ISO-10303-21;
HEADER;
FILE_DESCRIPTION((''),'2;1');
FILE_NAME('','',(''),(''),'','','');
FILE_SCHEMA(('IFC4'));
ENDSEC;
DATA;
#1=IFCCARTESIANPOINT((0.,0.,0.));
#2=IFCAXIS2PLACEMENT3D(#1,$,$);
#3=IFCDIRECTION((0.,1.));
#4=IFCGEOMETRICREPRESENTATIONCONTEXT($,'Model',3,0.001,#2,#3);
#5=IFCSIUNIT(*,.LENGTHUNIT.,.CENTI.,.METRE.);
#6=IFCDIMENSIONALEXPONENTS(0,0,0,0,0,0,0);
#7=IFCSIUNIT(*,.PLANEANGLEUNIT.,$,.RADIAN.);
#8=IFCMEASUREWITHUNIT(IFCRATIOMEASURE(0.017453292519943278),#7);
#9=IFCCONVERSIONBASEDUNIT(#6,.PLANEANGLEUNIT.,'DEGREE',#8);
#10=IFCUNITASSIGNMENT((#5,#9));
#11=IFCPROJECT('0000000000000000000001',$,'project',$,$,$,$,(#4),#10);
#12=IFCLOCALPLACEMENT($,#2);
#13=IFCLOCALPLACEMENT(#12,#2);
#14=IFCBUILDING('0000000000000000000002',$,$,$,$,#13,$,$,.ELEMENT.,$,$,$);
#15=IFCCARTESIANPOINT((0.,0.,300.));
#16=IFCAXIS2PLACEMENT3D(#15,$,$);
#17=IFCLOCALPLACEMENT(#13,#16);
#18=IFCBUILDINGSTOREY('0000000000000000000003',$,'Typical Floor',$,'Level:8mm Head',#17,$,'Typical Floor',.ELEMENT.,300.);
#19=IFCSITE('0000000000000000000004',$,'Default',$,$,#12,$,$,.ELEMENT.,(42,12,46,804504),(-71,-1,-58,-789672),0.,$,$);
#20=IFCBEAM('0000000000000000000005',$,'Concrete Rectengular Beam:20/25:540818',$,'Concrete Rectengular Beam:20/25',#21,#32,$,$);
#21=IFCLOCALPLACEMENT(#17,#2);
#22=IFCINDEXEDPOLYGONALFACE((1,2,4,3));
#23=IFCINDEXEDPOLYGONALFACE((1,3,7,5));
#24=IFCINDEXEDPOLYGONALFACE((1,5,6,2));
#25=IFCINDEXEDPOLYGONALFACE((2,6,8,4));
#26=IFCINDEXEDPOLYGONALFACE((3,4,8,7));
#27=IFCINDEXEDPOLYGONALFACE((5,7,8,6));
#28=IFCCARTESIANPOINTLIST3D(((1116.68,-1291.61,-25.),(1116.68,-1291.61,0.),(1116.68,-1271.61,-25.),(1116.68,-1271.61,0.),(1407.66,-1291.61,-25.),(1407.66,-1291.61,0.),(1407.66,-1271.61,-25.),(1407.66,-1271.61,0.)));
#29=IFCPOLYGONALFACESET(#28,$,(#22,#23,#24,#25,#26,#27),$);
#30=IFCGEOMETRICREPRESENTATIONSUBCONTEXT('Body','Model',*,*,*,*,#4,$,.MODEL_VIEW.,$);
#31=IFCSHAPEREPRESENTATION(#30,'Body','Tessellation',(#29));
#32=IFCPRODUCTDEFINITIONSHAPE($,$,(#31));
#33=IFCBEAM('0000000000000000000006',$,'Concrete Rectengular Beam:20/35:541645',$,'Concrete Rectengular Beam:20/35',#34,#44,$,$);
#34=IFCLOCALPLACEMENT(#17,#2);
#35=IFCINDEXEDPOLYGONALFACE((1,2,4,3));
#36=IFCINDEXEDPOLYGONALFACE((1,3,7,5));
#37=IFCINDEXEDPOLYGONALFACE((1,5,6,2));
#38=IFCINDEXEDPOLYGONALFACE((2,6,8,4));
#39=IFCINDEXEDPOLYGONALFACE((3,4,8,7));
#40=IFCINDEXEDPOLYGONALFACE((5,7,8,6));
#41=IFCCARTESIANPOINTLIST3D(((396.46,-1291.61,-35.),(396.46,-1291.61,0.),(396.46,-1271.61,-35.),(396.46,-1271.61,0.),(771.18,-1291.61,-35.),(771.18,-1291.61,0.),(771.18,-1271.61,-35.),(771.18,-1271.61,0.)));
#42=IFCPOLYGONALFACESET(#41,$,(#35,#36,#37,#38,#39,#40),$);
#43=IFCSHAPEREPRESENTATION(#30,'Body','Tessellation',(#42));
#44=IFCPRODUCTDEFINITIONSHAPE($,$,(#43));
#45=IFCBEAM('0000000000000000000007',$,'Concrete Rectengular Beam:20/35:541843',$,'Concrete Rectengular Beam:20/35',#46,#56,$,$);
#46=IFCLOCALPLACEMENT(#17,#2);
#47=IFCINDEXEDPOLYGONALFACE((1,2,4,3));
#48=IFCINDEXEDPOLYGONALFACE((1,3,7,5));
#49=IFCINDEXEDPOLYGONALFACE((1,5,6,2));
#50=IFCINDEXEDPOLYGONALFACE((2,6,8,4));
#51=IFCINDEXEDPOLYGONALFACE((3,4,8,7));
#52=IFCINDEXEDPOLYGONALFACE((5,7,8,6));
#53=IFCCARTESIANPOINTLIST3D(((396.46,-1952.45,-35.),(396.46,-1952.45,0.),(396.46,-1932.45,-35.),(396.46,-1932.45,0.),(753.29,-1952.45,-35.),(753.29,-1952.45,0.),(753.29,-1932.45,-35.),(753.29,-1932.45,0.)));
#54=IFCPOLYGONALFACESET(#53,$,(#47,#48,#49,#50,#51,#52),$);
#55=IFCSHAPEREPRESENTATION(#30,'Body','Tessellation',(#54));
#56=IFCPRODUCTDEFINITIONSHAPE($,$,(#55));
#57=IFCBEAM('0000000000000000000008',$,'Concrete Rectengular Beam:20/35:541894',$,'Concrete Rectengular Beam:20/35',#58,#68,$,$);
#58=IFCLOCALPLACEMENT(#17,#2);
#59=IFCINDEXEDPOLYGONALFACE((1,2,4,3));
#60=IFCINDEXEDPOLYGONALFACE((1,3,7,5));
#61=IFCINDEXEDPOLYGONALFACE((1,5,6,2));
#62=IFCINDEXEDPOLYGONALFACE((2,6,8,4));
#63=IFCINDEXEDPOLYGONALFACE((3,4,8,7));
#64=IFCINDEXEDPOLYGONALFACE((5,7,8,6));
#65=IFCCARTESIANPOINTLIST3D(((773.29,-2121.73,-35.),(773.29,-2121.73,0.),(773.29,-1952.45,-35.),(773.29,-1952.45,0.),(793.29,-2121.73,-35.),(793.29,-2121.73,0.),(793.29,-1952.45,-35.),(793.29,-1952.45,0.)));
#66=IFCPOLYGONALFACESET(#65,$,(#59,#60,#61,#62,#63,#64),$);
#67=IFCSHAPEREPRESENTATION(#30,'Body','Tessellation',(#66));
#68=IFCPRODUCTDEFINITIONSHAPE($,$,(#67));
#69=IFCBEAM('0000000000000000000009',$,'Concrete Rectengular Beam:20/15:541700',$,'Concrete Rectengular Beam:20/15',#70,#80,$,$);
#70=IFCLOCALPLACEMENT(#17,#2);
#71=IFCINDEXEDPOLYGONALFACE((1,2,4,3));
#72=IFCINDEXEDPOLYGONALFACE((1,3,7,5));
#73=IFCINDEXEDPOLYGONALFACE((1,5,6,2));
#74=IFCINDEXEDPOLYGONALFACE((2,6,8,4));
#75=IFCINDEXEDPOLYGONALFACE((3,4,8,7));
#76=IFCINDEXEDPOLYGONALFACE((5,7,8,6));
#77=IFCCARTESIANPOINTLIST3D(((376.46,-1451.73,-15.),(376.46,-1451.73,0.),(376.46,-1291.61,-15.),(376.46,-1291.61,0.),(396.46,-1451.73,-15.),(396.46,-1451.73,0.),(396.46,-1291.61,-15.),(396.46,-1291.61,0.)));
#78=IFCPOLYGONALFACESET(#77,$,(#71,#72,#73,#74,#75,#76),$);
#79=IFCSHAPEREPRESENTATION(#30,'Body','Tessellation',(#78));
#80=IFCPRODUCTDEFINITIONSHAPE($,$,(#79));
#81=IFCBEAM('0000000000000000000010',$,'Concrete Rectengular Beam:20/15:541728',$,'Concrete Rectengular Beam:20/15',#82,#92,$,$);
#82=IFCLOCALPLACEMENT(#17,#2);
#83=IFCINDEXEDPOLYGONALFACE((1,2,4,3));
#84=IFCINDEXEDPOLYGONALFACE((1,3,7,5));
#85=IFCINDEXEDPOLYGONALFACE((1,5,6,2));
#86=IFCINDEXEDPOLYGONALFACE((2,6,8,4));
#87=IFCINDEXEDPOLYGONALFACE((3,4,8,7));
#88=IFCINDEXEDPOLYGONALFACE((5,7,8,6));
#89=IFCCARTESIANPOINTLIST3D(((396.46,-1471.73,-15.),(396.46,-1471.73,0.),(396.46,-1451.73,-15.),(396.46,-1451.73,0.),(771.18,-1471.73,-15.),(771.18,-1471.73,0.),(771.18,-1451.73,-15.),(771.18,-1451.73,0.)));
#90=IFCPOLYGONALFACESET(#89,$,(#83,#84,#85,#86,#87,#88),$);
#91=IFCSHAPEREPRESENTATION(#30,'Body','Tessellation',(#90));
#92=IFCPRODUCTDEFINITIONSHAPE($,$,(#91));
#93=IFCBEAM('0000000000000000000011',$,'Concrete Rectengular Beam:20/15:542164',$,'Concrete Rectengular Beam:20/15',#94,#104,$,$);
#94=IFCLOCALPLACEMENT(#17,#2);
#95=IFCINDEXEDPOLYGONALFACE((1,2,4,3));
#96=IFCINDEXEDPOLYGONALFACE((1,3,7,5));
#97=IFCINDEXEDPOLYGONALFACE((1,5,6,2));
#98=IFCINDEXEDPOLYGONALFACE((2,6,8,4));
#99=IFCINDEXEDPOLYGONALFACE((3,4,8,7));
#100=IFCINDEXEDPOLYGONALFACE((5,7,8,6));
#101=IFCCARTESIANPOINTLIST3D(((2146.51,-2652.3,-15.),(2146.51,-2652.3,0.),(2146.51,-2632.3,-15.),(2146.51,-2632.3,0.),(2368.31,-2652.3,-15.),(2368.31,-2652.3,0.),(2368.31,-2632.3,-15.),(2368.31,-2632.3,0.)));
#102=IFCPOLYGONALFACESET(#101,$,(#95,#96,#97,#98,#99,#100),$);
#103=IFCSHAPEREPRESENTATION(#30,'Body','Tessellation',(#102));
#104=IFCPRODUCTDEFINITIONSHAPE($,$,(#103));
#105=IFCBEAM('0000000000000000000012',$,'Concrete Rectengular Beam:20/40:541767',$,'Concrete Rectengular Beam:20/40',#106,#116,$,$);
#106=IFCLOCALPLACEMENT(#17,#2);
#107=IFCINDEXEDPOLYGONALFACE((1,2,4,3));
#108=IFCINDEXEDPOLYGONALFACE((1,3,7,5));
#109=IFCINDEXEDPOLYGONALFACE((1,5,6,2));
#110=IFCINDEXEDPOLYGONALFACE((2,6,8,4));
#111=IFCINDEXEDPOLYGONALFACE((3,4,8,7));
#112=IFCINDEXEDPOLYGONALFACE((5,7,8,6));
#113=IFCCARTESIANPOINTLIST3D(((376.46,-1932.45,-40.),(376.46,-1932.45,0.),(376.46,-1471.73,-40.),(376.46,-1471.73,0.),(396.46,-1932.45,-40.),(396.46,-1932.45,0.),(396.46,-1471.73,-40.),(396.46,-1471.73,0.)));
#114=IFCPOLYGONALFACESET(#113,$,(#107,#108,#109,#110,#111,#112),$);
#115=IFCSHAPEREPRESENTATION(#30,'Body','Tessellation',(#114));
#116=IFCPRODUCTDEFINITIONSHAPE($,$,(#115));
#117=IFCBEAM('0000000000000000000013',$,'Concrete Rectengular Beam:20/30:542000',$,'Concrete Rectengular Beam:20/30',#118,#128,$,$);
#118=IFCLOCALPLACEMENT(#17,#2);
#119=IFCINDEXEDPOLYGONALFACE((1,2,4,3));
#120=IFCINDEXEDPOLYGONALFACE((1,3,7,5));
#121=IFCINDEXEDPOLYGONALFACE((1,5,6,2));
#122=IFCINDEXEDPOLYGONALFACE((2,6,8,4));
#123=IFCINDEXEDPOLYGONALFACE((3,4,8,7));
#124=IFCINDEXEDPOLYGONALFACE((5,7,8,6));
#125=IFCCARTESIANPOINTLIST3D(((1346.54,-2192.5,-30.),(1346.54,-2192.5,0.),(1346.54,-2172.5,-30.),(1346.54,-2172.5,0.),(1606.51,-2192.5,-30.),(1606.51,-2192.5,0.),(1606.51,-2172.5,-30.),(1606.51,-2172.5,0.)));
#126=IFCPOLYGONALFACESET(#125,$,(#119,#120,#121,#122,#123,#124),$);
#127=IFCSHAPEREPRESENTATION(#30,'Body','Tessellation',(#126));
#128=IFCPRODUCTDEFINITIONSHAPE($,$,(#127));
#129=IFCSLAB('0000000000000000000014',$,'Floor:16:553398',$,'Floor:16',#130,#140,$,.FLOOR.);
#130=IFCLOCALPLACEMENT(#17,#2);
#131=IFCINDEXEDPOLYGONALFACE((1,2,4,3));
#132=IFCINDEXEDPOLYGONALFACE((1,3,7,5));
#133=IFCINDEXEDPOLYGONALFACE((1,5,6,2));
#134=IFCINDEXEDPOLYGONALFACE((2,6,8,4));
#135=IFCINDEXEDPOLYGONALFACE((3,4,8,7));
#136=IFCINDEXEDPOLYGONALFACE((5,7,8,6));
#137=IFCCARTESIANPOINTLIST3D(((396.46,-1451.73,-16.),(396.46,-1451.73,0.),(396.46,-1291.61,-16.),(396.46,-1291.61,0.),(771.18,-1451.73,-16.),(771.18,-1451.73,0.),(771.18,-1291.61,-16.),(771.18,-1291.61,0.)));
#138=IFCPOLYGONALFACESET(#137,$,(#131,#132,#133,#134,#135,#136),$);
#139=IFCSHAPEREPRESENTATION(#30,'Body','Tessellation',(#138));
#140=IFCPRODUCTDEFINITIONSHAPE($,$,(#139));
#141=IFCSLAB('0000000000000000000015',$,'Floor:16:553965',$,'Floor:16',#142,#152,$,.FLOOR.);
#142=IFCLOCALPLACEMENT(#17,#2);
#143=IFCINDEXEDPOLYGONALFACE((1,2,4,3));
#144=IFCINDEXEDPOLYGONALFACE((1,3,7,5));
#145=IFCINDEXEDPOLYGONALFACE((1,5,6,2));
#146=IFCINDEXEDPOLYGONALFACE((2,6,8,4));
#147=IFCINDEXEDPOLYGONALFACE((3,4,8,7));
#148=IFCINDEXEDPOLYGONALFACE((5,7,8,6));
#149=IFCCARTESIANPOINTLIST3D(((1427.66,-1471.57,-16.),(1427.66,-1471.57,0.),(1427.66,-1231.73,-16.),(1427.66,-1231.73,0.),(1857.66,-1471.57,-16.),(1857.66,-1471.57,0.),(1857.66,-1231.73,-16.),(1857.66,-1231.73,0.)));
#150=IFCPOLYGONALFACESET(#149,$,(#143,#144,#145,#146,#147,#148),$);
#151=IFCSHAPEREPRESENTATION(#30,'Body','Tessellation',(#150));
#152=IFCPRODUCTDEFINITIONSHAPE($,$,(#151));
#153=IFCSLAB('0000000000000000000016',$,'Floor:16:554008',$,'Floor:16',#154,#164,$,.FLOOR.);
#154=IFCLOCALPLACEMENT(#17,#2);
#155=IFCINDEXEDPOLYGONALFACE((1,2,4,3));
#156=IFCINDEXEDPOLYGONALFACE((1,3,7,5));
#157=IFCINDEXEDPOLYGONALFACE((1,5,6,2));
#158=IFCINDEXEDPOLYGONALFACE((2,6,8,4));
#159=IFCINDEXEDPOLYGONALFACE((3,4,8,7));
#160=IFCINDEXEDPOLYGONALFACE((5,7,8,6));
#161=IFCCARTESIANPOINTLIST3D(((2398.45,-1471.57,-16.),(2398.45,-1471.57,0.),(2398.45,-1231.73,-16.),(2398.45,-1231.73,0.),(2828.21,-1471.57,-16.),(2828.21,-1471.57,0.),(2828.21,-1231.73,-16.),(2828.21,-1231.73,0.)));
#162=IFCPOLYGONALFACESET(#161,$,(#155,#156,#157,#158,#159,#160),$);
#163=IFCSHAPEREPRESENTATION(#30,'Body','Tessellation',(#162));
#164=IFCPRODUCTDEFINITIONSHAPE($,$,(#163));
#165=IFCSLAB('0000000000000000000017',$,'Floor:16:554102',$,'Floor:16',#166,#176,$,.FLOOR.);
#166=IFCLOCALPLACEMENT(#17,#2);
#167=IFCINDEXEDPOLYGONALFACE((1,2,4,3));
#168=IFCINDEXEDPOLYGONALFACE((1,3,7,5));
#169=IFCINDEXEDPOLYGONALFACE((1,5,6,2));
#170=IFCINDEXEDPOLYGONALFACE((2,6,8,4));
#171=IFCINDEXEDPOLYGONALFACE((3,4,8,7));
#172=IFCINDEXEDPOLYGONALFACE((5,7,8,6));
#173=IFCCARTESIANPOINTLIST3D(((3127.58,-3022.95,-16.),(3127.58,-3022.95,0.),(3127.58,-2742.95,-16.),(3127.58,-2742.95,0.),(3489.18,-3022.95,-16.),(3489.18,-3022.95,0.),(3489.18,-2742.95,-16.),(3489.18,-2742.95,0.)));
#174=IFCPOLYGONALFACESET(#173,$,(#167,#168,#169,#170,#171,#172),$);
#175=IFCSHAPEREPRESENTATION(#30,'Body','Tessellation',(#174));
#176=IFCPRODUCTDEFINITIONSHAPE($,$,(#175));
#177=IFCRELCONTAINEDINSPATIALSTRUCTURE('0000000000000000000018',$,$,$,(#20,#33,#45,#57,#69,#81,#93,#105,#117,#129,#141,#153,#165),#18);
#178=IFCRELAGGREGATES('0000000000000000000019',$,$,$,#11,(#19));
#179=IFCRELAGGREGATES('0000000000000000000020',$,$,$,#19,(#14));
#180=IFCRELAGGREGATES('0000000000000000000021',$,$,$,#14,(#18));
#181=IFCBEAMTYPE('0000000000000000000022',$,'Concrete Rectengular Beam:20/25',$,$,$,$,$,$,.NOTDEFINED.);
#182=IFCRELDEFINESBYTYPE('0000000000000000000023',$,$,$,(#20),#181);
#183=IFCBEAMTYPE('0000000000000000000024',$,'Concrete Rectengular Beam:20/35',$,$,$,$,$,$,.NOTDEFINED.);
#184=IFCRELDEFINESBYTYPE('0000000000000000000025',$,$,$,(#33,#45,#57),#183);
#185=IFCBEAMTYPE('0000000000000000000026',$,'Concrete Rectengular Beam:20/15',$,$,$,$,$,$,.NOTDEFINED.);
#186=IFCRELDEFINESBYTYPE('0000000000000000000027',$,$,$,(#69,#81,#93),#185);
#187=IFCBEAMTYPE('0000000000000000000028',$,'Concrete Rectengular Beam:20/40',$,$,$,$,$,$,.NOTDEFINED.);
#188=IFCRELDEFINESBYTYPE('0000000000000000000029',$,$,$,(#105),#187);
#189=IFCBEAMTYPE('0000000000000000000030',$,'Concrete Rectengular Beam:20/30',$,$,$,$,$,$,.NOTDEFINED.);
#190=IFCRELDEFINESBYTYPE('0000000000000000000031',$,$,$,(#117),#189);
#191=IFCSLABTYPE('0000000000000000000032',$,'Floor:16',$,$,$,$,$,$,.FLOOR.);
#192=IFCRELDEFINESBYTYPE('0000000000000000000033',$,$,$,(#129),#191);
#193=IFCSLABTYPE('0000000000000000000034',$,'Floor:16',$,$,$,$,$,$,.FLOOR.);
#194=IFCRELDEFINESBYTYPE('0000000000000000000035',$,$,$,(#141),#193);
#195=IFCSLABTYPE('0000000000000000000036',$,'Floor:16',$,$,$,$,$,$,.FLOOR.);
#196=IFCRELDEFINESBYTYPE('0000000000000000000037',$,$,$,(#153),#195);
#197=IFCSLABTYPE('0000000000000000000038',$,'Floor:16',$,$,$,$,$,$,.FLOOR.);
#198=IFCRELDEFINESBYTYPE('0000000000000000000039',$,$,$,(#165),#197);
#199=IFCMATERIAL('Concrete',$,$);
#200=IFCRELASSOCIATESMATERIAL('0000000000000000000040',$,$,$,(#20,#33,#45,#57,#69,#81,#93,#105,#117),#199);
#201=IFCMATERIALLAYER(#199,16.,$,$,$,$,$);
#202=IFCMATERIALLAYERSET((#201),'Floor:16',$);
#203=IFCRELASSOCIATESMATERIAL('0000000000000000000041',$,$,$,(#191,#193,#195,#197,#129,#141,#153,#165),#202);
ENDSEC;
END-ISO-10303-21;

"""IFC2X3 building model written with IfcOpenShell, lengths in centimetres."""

from ifc_helpers import new_model, entity, si_unit, converted_unit, direction, frame, frame_2d, origin, place, context, subcontext, project, spatial, rectangle, extrude, material, layer, layer_set, layer_usage, type_object, element, save


model = new_model("IFC2X3")

# Units and contexts
model_context = context("Model", 3, precision=0.001, world=origin(), true_north=direction((0.0, 1.0)))
body_context = subcontext(model_context, "Body", "Model", "MODEL_VIEW")
ifc_project = project(units=[si_unit("LENGTHUNIT", "METRE", prefix="CENTI"), converted_unit("PLANEANGLEUNIT", "DEGREE", entity("IfcRatioMeasure", 0.017453292519943278), si_unit("PLANEANGLEUNIT", "RADIAN"), dimensions=[0, 0, 0, 0, 0, 0, 0])], contexts=[model_context])

# Site, building, storey
site_placement = place(None, origin())
site = spatial("IfcSite", under=ifc_project, at=site_placement, Name="Default", CompositionType="ELEMENT", RefLatitude=(42, 12, 46, 804504), RefLongitude=(-71, -1, -58, -789672), RefElevation=0.0)
building_placement = place(site_placement, origin())
building = spatial("IfcBuilding", under=site, at=building_placement, CompositionType="ELEMENT")
storey_placement = place(building_placement, frame((0.0, 0.0, 300.0)))
storey = spatial("IfcBuildingStorey", under=building, at=storey_placement, Name="Typical Floor", ObjectType="Level:8mm Head", LongName="Typical Floor", CompositionType="ELEMENT", Elevation=300.0)

# Beams
ifc_material = material(Name="Concrete")
beam_type_1 = type_object("IfcBeamType", Name="Concrete Rectengular Beam:20/25", PredefinedType="NOTDEFINED")
beam_1_placement = place(storey_placement, frame((1417.66, -1281.61, 0.0), z_axis=(0.0, 0.0, 1.0), x_axis=(-1.0, 0.0, 0.0)))
element("IfcBeam", 1, at=beam_1_placement, inside=storey, type_object=beam_type_1, material=ifc_material, Name="Concrete Rectengular Beam:20/25:540818", ObjectType="Concrete Rectengular Beam:20/25", context=body_context, shape_type="SweptSolid", body=[
    extrude(rectangle(XDim=25.0, YDim=20.0, at=frame_2d((0.0, 0.0), x_axis=(1.0, 0.0))), frame((10.0, 0.0, -12.5), z_axis=(1.0, 0.0, 0.0), x_axis=(0.0, 0.0, -1.0)), (0.0, 0.0, 1.0), 290.98),
])
beam_type_2 = type_object("IfcBeamType", Name="Concrete Rectengular Beam:20/35", PredefinedType="NOTDEFINED")
beam_2_placement = place(storey_placement, frame((386.46, -1281.61, 0.0)))
element("IfcBeam", 2, at=beam_2_placement, inside=storey, type_object=beam_type_2, material=ifc_material, Name="Concrete Rectengular Beam:20/35:541645", ObjectType="Concrete Rectengular Beam:20/35", context=body_context, shape_type="SweptSolid", body=[
    extrude(rectangle(XDim=35.0, YDim=20.0, at=frame_2d((0.0, 0.0), x_axis=(1.0, 0.0))), frame((10.0, 0.0, -17.5), z_axis=(1.0, 0.0, 0.0), x_axis=(0.0, 0.0, -1.0)), (0.0, 0.0, 1.0), 374.72),
])
beam_3_placement = place(storey_placement, frame((386.46, -1942.45, 0.0)))
element("IfcBeam", 3, at=beam_3_placement, inside=storey, type_object=beam_type_2, material=ifc_material, Name="Concrete Rectengular Beam:20/35:541843", ObjectType="Concrete Rectengular Beam:20/35", context=body_context, shape_type="SweptSolid", body=[
    extrude(rectangle(XDim=35.0, YDim=20.0, at=frame_2d((0.0, 0.0), x_axis=(1.0, 0.0))), frame((10.0, 0.0, -17.5), z_axis=(1.0, 0.0, 0.0), x_axis=(0.0, 0.0, -1.0)), (0.0, 0.0, 1.0), 356.83),
])
beam_4_placement = place(storey_placement, frame((783.29, -1942.45, 0.0), z_axis=(0.0, 0.0, 1.0), x_axis=(0.0, -1.0, 0.0)))
element("IfcBeam", 4, at=beam_4_placement, inside=storey, type_object=beam_type_2, material=ifc_material, Name="Concrete Rectengular Beam:20/35:541894", ObjectType="Concrete Rectengular Beam:20/35", context=body_context, shape_type="SweptSolid", body=[
    extrude(rectangle(XDim=35.0, YDim=20.0, at=frame_2d((0.0, 0.0), x_axis=(1.0, 0.0))), frame((10.0, 0.0, -17.5), z_axis=(1.0, 0.0, 0.0), x_axis=(0.0, 0.0, -1.0)), (0.0, 0.0, 1.0), 169.28),
])
beam_type_3 = type_object("IfcBeamType", Name="Concrete Rectengular Beam:20/15", PredefinedType="NOTDEFINED")
beam_5_placement = place(storey_placement, frame((386.46, -1281.61, 0.0), z_axis=(0.0, 0.0, 1.0), x_axis=(0.0, -1.0, 0.0)))
element("IfcBeam", 5, at=beam_5_placement, inside=storey, type_object=beam_type_3, material=ifc_material, Name="Concrete Rectengular Beam:20/15:541700", ObjectType="Concrete Rectengular Beam:20/15", context=body_context, shape_type="SweptSolid", body=[
    extrude(rectangle(XDim=15.0, YDim=20.0, at=frame_2d((0.0, 0.0), x_axis=(1.0, 0.0))), frame((10.0, 0.0, -7.5), z_axis=(1.0, 0.0, 0.0), x_axis=(0.0, 0.0, -1.0)), (0.0, 0.0, 1.0), 160.12),
])
beam_6_placement = place(storey_placement, frame((386.46, -1461.73, 0.0)))
element("IfcBeam", 6, at=beam_6_placement, inside=storey, type_object=beam_type_3, material=ifc_material, Name="Concrete Rectengular Beam:20/15:541728", ObjectType="Concrete Rectengular Beam:20/15", context=body_context, shape_type="SweptSolid", body=[
    extrude(rectangle(XDim=15.0, YDim=20.0, at=frame_2d((0.0, 0.0), x_axis=(1.0, 0.0))), frame((10.0, 0.0, -7.5), z_axis=(1.0, 0.0, 0.0), x_axis=(0.0, 0.0, -1.0)), (0.0, 0.0, 1.0), 374.72),
])
beam_7_placement = place(storey_placement, frame((2136.51, -2642.3, 0.0)))
element("IfcBeam", 7, at=beam_7_placement, inside=storey, type_object=beam_type_3, material=ifc_material, Name="Concrete Rectengular Beam:20/15:542164", ObjectType="Concrete Rectengular Beam:20/15", context=body_context, shape_type="SweptSolid", body=[
    extrude(rectangle(XDim=15.0, YDim=20.0, at=frame_2d((0.0, 0.0), x_axis=(1.0, 0.0))), frame((10.0, 0.0, -7.5), z_axis=(1.0, 0.0, 0.0), x_axis=(0.0, 0.0, -1.0)), (0.0, 0.0, 1.0), 221.8),
])
beam_type_4 = type_object("IfcBeamType", Name="Concrete Rectengular Beam:20/40", PredefinedType="NOTDEFINED")
beam_8_placement = place(storey_placement, frame((386.46, -1461.73, 0.0), z_axis=(0.0, 0.0, 1.0), x_axis=(0.0, -1.0, 0.0)))
element("IfcBeam", 8, at=beam_8_placement, inside=storey, type_object=beam_type_4, material=ifc_material, Name="Concrete Rectengular Beam:20/40:541767", ObjectType="Concrete Rectengular Beam:20/40", context=body_context, shape_type="SweptSolid", body=[
    extrude(rectangle(XDim=40.0, YDim=20.0, at=frame_2d((0.0, 0.0), x_axis=(1.0, 0.0))), frame((10.0, 0.0, -20.0), z_axis=(1.0, 0.0, 0.0), x_axis=(0.0, 0.0, -1.0)), (0.0, 0.0, 1.0), 460.73),
])
beam_type_5 = type_object("IfcBeamType", Name="Concrete Rectengular Beam:20/30", PredefinedType="NOTDEFINED")
beam_9_placement = place(storey_placement, frame((1336.54, -2182.5, 0.0)))
element("IfcBeam", 9, at=beam_9_placement, inside=storey, type_object=beam_type_5, material=ifc_material, Name="Concrete Rectengular Beam:20/30:542000", ObjectType="Concrete Rectengular Beam:20/30", context=body_context, shape_type="SweptSolid", body=[
    extrude(rectangle(XDim=30.0, YDim=20.0, at=frame_2d((0.0, 0.0), x_axis=(1.0, 0.0))), frame((10.0, 0.0, -15.0), z_axis=(1.0, 0.0, 0.0), x_axis=(0.0, 0.0, -1.0)), (0.0, 0.0, 1.0), 259.96),
])

# Slabs
ifc_layer = layer(ifc_material, 16.0)
ifc_layer_set = layer_set([ifc_layer], Name="Floor:16")
ifc_layer_usage_1 = layer_usage(ifc_layer_set, "AXIS3", "POSITIVE", 0.0)
slab_type_1 = type_object("IfcSlabType", Name="Floor:16", PredefinedType="FLOOR", material=ifc_layer_set)
slab_1_placement = place(storey_placement, origin())
element("IfcSlab", 10, at=slab_1_placement, inside=storey, type_object=slab_type_1, material=ifc_layer_usage_1, Name="Floor:16:553398", ObjectType="Floor:16", PredefinedType="FLOOR", context=body_context, shape_type="SweptSolid", body=[
    extrude(rectangle(XDim=160.12, YDim=374.72, at=frame_2d((0.0, 0.0), x_axis=(1.0, 0.0))), frame((583.82, -1371.67, 0.0), z_axis=(0.0, 0.0, -1.0), x_axis=(0.0, 1.0, 0.0)), (0.0, 0.0, 1.0), 16.0),
])
ifc_layer_usage_2 = layer_usage(ifc_layer_set, "AXIS3", "POSITIVE", 0.0)
slab_type_2 = type_object("IfcSlabType", Name="Floor:16", PredefinedType="FLOOR", material=ifc_layer_set)
slab_2_placement = place(storey_placement, origin())
element("IfcSlab", 11, at=slab_2_placement, inside=storey, type_object=slab_type_2, material=ifc_layer_usage_2, Name="Floor:16:553965", ObjectType="Floor:16", PredefinedType="FLOOR", context=body_context, shape_type="SweptSolid", body=[
    extrude(rectangle(XDim=239.85, YDim=430.0, at=frame_2d((0.0, 0.0), x_axis=(1.0, 0.0))), frame((1642.66, -1351.65, 0.0), z_axis=(0.0, 0.0, -1.0), x_axis=(0.0, 1.0, 0.0)), (0.0, 0.0, 1.0), 16.0),
])
ifc_layer_usage_3 = layer_usage(ifc_layer_set, "AXIS3", "POSITIVE", 0.0)
slab_type_3 = type_object("IfcSlabType", Name="Floor:16", PredefinedType="FLOOR", material=ifc_layer_set)
slab_3_placement = place(storey_placement, origin())
element("IfcSlab", 12, at=slab_3_placement, inside=storey, type_object=slab_type_3, material=ifc_layer_usage_3, Name="Floor:16:554008", ObjectType="Floor:16", PredefinedType="FLOOR", context=body_context, shape_type="SweptSolid", body=[
    extrude(rectangle(XDim=239.85, YDim=429.76, at=frame_2d((0.0, 0.0), x_axis=(1.0, 0.0))), frame((2613.33, -1351.65, 0.0), z_axis=(0.0, 0.0, -1.0), x_axis=(0.0, 1.0, 0.0)), (0.0, 0.0, 1.0), 16.0),
])
ifc_layer_usage_4 = layer_usage(ifc_layer_set, "AXIS3", "POSITIVE", 0.0)
slab_type_4 = type_object("IfcSlabType", Name="Floor:16", PredefinedType="FLOOR", material=ifc_layer_set)
slab_4_placement = place(storey_placement, origin())
element("IfcSlab", 13, at=slab_4_placement, inside=storey, type_object=slab_type_4, material=ifc_layer_usage_4, Name="Floor:16:554102", ObjectType="Floor:16", PredefinedType="FLOOR", context=body_context, shape_type="SweptSolid", body=[
    extrude(rectangle(XDim=280.0, YDim=361.6, at=frame_2d((0.0, 0.0), x_axis=(1.0, 0.0))), frame((3308.38, -2882.95, 0.0), z_axis=(0.0, 0.0, -1.0), x_axis=(0.0, 1.0, 0.0)), (0.0, 0.0, 1.0), 16.0),
])

save(model, "model.ifc")
